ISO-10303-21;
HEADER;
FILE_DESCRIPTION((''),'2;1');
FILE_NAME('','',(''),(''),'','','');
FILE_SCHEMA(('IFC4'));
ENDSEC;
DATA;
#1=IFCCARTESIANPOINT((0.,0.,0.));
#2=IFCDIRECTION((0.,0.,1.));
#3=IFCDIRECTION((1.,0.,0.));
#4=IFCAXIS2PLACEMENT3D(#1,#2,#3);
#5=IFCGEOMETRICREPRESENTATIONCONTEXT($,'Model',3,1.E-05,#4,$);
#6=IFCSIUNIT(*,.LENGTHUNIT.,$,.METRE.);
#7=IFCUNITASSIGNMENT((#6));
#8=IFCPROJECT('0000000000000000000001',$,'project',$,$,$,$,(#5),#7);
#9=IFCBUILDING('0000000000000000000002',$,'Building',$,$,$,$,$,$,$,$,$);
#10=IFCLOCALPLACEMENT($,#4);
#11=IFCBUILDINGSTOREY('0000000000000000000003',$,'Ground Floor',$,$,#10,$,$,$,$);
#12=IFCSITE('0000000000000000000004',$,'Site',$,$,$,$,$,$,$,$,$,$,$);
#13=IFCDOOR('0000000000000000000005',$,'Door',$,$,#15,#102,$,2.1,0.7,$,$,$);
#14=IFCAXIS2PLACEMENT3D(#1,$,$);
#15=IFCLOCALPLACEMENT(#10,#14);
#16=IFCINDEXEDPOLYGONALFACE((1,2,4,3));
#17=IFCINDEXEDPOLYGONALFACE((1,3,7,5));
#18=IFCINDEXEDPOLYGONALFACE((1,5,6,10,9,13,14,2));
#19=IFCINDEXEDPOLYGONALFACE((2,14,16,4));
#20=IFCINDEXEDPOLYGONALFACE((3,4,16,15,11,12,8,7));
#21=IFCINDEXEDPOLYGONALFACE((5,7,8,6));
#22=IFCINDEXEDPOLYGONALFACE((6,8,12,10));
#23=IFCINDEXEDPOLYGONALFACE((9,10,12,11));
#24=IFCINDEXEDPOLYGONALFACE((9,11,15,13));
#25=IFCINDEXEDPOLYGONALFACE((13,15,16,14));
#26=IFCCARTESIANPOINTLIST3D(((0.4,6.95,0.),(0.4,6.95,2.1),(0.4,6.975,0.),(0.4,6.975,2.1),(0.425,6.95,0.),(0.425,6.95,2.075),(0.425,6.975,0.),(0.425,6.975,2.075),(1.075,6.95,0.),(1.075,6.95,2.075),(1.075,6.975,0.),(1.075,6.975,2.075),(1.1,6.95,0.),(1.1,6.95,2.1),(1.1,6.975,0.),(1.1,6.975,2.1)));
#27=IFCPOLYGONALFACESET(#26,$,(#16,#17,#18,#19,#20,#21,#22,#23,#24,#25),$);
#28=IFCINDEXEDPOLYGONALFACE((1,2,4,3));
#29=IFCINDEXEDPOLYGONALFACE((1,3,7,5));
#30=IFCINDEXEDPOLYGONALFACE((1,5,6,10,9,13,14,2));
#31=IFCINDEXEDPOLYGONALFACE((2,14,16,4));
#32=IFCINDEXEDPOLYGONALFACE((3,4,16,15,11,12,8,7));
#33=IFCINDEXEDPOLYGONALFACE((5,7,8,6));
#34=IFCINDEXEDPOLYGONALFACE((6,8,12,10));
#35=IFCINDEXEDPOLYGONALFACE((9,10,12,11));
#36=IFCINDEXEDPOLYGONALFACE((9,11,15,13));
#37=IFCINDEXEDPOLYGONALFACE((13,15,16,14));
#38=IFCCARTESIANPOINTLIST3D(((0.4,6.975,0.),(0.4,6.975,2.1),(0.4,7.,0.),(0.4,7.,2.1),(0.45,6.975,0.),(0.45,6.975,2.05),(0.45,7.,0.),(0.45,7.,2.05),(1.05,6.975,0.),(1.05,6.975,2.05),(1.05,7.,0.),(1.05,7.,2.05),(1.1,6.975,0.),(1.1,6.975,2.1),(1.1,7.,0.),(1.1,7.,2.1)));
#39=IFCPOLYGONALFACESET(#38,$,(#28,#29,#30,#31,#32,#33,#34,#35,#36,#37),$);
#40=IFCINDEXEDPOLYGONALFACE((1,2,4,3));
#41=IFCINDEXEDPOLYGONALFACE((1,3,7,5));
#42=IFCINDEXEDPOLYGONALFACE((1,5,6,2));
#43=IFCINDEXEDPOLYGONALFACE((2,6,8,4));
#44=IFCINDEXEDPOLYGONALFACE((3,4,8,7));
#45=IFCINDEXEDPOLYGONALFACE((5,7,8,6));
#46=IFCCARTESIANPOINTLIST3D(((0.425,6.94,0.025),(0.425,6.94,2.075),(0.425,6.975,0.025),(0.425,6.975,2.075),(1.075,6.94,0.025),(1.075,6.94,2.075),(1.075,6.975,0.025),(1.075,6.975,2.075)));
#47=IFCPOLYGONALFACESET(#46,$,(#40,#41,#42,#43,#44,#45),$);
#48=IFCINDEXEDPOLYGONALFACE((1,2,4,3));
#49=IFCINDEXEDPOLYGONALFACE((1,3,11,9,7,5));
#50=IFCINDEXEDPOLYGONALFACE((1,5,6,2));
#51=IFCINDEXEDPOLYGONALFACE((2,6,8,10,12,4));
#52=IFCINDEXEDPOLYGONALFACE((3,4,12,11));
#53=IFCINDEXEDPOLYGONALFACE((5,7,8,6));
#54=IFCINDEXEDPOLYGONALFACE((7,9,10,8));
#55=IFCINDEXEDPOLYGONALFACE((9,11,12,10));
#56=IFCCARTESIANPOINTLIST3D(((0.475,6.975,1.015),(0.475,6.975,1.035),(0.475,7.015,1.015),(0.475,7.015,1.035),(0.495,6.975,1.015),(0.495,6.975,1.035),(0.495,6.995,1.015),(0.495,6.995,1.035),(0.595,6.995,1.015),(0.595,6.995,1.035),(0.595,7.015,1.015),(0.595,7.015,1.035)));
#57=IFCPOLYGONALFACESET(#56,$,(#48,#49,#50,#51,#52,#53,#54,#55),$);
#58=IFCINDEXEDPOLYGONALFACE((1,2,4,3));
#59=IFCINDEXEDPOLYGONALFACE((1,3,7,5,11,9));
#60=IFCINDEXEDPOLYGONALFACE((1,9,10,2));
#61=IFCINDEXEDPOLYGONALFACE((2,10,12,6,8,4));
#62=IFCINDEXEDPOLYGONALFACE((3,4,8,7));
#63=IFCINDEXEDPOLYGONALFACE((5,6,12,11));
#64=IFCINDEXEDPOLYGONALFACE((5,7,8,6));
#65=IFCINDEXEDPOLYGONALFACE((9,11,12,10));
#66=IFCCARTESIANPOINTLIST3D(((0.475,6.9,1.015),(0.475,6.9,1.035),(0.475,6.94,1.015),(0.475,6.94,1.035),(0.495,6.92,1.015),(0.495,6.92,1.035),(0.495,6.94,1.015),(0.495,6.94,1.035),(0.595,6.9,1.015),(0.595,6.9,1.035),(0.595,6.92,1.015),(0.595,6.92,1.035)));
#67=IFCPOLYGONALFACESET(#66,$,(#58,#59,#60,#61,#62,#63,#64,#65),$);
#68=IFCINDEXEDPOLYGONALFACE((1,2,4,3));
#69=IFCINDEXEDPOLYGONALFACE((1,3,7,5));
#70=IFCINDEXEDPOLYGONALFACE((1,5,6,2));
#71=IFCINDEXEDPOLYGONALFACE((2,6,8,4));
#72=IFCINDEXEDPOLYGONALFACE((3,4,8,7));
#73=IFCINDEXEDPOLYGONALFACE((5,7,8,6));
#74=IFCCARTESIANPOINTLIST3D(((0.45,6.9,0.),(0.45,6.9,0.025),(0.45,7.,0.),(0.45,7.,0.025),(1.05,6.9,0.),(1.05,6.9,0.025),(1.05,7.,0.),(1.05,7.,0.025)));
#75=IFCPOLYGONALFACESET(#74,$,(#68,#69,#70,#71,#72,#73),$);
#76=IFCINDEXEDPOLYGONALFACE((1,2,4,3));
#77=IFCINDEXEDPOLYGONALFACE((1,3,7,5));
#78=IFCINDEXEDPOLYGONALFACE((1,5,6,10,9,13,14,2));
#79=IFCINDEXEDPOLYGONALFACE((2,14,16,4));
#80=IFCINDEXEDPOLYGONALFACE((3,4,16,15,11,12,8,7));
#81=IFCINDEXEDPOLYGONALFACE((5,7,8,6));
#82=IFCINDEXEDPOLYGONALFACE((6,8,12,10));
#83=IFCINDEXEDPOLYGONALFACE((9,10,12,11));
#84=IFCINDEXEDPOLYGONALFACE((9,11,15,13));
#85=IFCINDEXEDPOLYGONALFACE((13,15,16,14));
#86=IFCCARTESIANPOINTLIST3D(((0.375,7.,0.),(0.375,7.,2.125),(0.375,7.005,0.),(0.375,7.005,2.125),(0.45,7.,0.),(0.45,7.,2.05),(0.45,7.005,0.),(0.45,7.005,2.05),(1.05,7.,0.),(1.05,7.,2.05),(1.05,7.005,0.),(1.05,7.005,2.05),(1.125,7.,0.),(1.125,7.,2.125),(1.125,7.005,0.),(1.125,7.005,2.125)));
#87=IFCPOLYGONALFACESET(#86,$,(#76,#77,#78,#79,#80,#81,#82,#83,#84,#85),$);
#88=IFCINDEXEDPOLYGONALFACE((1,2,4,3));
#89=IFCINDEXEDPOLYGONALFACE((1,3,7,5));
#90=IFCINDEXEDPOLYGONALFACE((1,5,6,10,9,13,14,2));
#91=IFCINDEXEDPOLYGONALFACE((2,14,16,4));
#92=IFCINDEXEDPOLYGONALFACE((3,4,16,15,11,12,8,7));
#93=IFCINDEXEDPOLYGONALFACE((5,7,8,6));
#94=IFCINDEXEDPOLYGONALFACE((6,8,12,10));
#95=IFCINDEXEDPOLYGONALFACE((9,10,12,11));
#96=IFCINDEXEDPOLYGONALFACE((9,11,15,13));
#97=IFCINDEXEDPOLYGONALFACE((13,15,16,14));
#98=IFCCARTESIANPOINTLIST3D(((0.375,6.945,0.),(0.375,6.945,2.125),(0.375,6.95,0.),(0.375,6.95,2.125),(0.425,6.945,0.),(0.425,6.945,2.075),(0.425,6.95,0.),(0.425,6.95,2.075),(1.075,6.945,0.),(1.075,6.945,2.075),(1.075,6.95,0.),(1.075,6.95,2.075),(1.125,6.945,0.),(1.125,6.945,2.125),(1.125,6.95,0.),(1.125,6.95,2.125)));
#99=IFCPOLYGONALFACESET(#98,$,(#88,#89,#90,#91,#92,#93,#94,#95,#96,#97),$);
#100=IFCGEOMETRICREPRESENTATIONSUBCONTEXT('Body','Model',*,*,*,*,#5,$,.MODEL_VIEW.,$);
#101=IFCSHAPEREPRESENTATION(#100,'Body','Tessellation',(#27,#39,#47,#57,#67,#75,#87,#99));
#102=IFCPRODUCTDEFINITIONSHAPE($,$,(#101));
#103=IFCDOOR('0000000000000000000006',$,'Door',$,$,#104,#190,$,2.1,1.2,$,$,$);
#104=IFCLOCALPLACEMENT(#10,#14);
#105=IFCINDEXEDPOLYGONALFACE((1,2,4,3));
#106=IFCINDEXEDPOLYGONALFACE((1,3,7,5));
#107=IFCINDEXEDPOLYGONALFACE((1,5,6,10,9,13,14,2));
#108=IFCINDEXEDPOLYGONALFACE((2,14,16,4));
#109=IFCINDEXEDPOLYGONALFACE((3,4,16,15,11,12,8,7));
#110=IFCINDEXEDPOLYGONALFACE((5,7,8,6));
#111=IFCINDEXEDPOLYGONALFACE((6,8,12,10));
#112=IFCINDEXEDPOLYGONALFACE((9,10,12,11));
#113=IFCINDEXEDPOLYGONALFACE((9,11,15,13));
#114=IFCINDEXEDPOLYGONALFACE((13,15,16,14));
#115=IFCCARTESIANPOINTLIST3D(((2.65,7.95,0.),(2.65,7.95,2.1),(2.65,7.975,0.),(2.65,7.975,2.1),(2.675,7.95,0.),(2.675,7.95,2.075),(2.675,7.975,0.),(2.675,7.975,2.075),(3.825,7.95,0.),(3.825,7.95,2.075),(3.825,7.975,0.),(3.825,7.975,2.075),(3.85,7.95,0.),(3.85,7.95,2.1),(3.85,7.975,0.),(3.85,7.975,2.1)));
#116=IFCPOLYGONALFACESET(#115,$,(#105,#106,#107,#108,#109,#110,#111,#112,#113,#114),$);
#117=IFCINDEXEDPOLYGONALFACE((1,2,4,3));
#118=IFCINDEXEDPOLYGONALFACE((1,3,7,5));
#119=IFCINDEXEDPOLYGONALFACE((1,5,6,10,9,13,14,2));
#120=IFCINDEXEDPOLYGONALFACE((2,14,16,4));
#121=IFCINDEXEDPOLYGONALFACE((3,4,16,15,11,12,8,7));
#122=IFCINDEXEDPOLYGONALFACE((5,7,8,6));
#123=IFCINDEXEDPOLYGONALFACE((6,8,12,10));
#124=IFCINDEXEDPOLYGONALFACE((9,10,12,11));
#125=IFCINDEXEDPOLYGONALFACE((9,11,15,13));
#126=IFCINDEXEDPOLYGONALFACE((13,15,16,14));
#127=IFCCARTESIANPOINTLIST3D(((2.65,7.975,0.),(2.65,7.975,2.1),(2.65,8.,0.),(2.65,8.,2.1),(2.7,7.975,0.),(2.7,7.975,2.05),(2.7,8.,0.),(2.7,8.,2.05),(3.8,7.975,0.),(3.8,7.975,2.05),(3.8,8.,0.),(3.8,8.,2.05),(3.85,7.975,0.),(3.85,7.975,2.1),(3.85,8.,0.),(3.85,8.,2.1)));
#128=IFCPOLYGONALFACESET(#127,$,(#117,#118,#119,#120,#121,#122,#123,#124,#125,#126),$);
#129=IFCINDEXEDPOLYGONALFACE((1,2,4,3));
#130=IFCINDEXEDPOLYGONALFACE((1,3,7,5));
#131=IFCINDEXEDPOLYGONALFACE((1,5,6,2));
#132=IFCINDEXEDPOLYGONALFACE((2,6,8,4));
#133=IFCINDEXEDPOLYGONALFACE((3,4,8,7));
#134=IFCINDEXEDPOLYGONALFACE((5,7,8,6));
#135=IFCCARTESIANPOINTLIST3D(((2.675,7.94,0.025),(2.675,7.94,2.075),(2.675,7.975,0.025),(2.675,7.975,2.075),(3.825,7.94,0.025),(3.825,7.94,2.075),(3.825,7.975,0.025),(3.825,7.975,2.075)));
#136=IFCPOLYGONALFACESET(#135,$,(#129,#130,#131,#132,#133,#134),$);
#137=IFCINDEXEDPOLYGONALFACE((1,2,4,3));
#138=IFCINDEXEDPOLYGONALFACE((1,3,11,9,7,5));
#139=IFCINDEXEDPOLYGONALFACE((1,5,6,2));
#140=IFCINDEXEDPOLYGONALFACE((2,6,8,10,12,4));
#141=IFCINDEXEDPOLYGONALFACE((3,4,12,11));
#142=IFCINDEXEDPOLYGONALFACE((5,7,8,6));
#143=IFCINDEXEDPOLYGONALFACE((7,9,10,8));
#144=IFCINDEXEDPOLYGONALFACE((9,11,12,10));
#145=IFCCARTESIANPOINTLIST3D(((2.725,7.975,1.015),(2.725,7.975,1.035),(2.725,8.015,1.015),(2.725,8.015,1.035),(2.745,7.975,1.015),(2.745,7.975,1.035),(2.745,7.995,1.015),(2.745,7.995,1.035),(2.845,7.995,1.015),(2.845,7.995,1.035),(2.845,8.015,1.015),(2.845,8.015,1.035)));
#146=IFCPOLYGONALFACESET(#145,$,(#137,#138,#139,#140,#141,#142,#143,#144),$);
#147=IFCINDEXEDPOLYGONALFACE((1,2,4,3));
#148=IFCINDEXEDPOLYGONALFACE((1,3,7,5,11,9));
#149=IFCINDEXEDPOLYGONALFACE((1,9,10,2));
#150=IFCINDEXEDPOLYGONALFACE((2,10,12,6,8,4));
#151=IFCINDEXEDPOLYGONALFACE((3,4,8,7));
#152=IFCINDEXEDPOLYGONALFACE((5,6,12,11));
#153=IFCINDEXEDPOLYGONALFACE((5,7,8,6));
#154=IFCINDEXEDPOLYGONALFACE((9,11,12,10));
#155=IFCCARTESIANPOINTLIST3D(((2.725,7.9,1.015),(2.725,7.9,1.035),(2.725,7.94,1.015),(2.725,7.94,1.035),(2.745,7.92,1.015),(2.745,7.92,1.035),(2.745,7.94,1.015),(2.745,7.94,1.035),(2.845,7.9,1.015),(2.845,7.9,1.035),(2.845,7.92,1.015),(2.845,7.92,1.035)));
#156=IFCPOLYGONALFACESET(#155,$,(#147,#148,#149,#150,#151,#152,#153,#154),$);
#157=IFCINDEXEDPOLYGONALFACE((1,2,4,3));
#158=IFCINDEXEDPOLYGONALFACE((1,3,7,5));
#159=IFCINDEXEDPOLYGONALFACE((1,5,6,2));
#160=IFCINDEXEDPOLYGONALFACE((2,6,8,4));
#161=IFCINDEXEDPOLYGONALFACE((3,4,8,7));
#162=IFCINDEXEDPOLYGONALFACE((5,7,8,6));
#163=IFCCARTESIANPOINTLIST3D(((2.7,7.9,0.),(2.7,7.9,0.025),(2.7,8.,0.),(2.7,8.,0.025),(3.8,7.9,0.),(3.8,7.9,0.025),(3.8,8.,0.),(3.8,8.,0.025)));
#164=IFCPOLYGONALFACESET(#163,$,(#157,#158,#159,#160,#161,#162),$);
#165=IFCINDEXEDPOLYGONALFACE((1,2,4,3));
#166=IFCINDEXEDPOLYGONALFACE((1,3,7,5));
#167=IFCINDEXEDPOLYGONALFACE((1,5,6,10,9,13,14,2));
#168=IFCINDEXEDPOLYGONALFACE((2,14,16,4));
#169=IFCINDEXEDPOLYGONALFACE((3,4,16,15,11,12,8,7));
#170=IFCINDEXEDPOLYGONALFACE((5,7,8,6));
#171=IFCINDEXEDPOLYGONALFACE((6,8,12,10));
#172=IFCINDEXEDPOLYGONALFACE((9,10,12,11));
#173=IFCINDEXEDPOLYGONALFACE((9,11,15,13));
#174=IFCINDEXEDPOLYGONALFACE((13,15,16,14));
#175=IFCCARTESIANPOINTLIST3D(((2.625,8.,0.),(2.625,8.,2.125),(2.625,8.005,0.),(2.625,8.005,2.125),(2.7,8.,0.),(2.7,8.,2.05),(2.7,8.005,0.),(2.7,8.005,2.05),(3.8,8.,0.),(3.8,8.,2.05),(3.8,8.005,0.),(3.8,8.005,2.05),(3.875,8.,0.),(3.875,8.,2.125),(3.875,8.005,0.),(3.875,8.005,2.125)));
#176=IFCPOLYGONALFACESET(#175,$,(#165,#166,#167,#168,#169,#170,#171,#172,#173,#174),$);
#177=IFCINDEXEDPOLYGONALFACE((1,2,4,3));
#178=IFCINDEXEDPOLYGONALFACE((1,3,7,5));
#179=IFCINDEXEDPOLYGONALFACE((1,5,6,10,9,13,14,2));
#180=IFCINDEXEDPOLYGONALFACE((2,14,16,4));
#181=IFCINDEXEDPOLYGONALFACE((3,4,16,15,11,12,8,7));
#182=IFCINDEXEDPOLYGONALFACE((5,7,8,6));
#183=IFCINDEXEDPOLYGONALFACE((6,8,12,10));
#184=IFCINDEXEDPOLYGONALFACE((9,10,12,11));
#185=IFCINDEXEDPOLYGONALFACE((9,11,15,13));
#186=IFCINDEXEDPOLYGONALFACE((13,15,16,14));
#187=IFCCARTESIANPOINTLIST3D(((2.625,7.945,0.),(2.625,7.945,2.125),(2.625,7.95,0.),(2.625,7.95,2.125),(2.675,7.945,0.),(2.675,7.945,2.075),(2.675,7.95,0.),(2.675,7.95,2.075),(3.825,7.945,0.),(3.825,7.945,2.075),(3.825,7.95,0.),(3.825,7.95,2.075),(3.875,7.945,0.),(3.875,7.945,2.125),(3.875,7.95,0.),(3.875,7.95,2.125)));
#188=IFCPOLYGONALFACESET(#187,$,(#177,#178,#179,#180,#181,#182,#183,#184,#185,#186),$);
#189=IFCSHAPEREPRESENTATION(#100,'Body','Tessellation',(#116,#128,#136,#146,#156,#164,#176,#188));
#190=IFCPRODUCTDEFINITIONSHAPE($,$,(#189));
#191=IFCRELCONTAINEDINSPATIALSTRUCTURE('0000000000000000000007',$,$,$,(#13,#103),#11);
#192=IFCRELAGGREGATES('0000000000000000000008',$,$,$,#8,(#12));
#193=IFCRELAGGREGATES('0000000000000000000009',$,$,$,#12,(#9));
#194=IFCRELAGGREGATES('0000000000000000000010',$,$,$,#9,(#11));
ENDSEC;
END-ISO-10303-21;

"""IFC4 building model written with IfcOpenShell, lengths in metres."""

from ifc_helpers import new_model, si_unit, frame, origin_with_axes, place, context, subcontext, project, spatial, line, indexed_curve, outline, extrude, element, save


model = new_model("IFC4")

# Units and contexts
model_context = context("Model", 3, precision=1e-05, world=origin_with_axes())
body_context = subcontext(model_context, "Body", "Model", "MODEL_VIEW")
ifc_project = project(units=[si_unit("LENGTHUNIT", "METRE")], contexts=[model_context])

# Site, building, storey
site = spatial("IfcSite", under=ifc_project, Name="Site")
building = spatial("IfcBuilding", under=site, Name="Building")
storey_placement = place(None, origin_with_axes())
storey = spatial("IfcBuildingStorey", under=building, at=storey_placement, Name="Ground Floor")

# Doors
door_1_placement = place(storey_placement, frame((1.1, 7.0, 0.0), z_axis=(0.0, 0.0, 1.0), x_axis=(-1.0, 0.0, 0.0)))
element("IfcDoor", 1, at=door_1_placement, inside=storey, Name="Door", OverallHeight=2.1, OverallWidth=0.7, context=body_context, shape_type="SweptSolid", body=[
    extrude(outline(indexed_curve([(0.0, 0.0), (0.0, 2.1), (0.7, 2.1), (0.7, 0.0), (0.675, 0.0), (0.675, 2.075), (0.025, 2.075), (0.025, 0.0)], segments=[line(1, 2, 3, 4, 5, 6, 7, 8, 1)])), frame((0.0, 0.025, 0.0), z_axis=(0.0, -1.0, 0.0), x_axis=(1.0, 0.0, 0.0)), (0.0, 0.0, -1.0), 0.025),
    extrude(outline(indexed_curve([(0.0, 0.0), (0.0, 2.1), (0.7, 2.1), (0.7, 0.0), (0.65, 0.0), (0.65, 2.05), (0.05, 2.05), (0.05, 0.0)], segments=[line(1, 2, 3, 4, 5, 6, 7, 8, 1)])), frame((0.0, 0.0, 0.0), z_axis=(0.0, -1.0, 0.0), x_axis=(1.0, 0.0, 0.0)), (0.0, 0.0, -1.0), 0.025),
    extrude(outline(indexed_curve([(0.0, 0.0), (0.65, 0.0), (0.65, 0.035), (0.0, 0.035)], segments=[line(1, 2, 3, 4, 1)])), frame((0.025, 0.025, 0.025), z_axis=(0.0, 0.0, 1.0), x_axis=(1.0, 0.0, 0.0)), (0.0, 0.0, 1.0), 2.05),
    extrude(outline(indexed_curve([(0.0, 0.0), (0.0, -0.04), (-0.12, -0.04), (-0.12, -0.02), (-0.02, -0.02), (-0.02, 0.0)], segments=[line(1, 2, 3, 4, 5, 6, 1)])), frame((0.625, 0.025, 1.015), z_axis=(0.0, 0.0, 1.0), x_axis=(1.0, 0.0, 0.0)), (0.0, 0.0, 1.0), 0.02),
    extrude(outline(indexed_curve([(0.0, 0.0), (0.0, 0.04), (-0.12, 0.04), (-0.12, 0.02), (-0.02, 0.02), (-0.02, 0.0)], segments=[line(1, 2, 3, 4, 5, 6, 1)])), frame((0.625, 0.06, 1.015), z_axis=(0.0, 0.0, 1.0), x_axis=(1.0, 0.0, 0.0)), (0.0, 0.0, 1.0), 0.02),
    extrude(outline(indexed_curve([(0.0, 0.0), (0.6, 0.0), (0.6, 0.1), (0.0, 0.1)], segments=[line(1, 2, 3, 4, 1)])), frame((0.05, 0.0, 0.0), z_axis=(0.0, 0.0, 1.0), x_axis=(1.0, 0.0, 0.0)), (0.0, 0.0, 1.0), 0.025),
    extrude(outline(indexed_curve([(0.0, 0.0), (0.0, 2.125), (0.75, 2.125), (0.75, 0.0), (0.675, 0.0), (0.675, 2.05), (0.075, 2.05), (0.075, 0.0)], segments=[line(1, 2, 3, 4, 5, 6, 7, 8, 1)])), frame((-0.025, -0.005, 0.0), z_axis=(0.0, -1.0, 0.0), x_axis=(1.0, 0.0, 0.0)), (0.0, 0.0, -1.0), 0.005),
    extrude(outline(indexed_curve([(0.0, 0.0), (0.0, 2.125), (0.75, 2.125), (0.75, 0.0), (0.7, 0.0), (0.7, 2.075), (0.05, 2.075), (0.05, 0.0)], segments=[line(1, 2, 3, 4, 5, 6, 7, 8, 1)])), frame((-0.025, 0.05, 0.0), z_axis=(0.0, -1.0, 0.0), x_axis=(1.0, 0.0, 0.0)), (0.0, 0.0, -1.0), 0.005),
])
door_2_placement = place(storey_placement, frame((3.85, 8.0, 0.0), z_axis=(0.0, 0.0, 1.0), x_axis=(-1.0, 0.0, 0.0)))
element("IfcDoor", 2, at=door_2_placement, inside=storey, Name="Door", OverallHeight=2.1, OverallWidth=1.2, context=body_context, shape_type="SweptSolid", body=[
    extrude(outline(indexed_curve([(0.0, 0.0), (0.0, 2.1), (1.2, 2.1), (1.2, 0.0), (1.175, 0.0), (1.175, 2.075), (0.025, 2.075), (0.025, 0.0)], segments=[line(1, 2, 3, 4, 5, 6, 7, 8, 1)])), frame((0.0, 0.025, 0.0), z_axis=(0.0, -1.0, 0.0), x_axis=(1.0, 0.0, 0.0)), (0.0, 0.0, -1.0), 0.025),
    extrude(outline(indexed_curve([(0.0, 0.0), (0.0, 2.1), (1.2, 2.1), (1.2, 0.0), (1.15, 0.0), (1.15, 2.05), (0.05, 2.05), (0.05, 0.0)], segments=[line(1, 2, 3, 4, 5, 6, 7, 8, 1)])), frame((0.0, 0.0, 0.0), z_axis=(0.0, -1.0, 0.0), x_axis=(1.0, 0.0, 0.0)), (0.0, 0.0, -1.0), 0.025),
    extrude(outline(indexed_curve([(0.0, 0.0), (1.15, 0.0), (1.15, 0.035), (0.0, 0.035)], segments=[line(1, 2, 3, 4, 1)])), frame((0.025, 0.025, 0.025), z_axis=(0.0, 0.0, 1.0), x_axis=(1.0, 0.0, 0.0)), (0.0, 0.0, 1.0), 2.05),
    extrude(outline(indexed_curve([(0.0, 0.0), (0.0, -0.04), (-0.12, -0.04), (-0.12, -0.02), (-0.02, -0.02), (-0.02, 0.0)], segments=[line(1, 2, 3, 4, 5, 6, 1)])), frame((1.125, 0.025, 1.015), z_axis=(0.0, 0.0, 1.0), x_axis=(1.0, 0.0, 0.0)), (0.0, 0.0, 1.0), 0.02),
    extrude(outline(indexed_curve([(0.0, 0.0), (0.0, 0.04), (-0.12, 0.04), (-0.12, 0.02), (-0.02, 0.02), (-0.02, 0.0)], segments=[line(1, 2, 3, 4, 5, 6, 1)])), frame((1.125, 0.06, 1.015), z_axis=(0.0, 0.0, 1.0), x_axis=(1.0, 0.0, 0.0)), (0.0, 0.0, 1.0), 0.02),
    extrude(outline(indexed_curve([(0.0, 0.0), (1.1, 0.0), (1.1, 0.1), (0.0, 0.1)], segments=[line(1, 2, 3, 4, 1)])), frame((0.05, 0.0, 0.0), z_axis=(0.0, 0.0, 1.0), x_axis=(1.0, 0.0, 0.0)), (0.0, 0.0, 1.0), 0.025),
    extrude(outline(indexed_curve([(0.0, 0.0), (0.0, 2.125), (1.25, 2.125), (1.25, 0.0), (1.175, 0.0), (1.175, 2.05), (0.075, 2.05), (0.075, 0.0)], segments=[line(1, 2, 3, 4, 5, 6, 7, 8, 1)])), frame((-0.025, -0.005, 0.0), z_axis=(0.0, -1.0, 0.0), x_axis=(1.0, 0.0, 0.0)), (0.0, 0.0, -1.0), 0.005),
    extrude(outline(indexed_curve([(0.0, 0.0), (0.0, 2.125), (1.25, 2.125), (1.25, 0.0), (1.2, 0.0), (1.2, 2.075), (0.05, 2.075), (0.05, 0.0)], segments=[line(1, 2, 3, 4, 5, 6, 7, 8, 1)])), frame((-0.025, 0.05, 0.0), z_axis=(0.0, -1.0, 0.0), x_axis=(1.0, 0.0, 0.0)), (0.0, 0.0, -1.0), 0.005),
])

save(model, "model.ifc")
